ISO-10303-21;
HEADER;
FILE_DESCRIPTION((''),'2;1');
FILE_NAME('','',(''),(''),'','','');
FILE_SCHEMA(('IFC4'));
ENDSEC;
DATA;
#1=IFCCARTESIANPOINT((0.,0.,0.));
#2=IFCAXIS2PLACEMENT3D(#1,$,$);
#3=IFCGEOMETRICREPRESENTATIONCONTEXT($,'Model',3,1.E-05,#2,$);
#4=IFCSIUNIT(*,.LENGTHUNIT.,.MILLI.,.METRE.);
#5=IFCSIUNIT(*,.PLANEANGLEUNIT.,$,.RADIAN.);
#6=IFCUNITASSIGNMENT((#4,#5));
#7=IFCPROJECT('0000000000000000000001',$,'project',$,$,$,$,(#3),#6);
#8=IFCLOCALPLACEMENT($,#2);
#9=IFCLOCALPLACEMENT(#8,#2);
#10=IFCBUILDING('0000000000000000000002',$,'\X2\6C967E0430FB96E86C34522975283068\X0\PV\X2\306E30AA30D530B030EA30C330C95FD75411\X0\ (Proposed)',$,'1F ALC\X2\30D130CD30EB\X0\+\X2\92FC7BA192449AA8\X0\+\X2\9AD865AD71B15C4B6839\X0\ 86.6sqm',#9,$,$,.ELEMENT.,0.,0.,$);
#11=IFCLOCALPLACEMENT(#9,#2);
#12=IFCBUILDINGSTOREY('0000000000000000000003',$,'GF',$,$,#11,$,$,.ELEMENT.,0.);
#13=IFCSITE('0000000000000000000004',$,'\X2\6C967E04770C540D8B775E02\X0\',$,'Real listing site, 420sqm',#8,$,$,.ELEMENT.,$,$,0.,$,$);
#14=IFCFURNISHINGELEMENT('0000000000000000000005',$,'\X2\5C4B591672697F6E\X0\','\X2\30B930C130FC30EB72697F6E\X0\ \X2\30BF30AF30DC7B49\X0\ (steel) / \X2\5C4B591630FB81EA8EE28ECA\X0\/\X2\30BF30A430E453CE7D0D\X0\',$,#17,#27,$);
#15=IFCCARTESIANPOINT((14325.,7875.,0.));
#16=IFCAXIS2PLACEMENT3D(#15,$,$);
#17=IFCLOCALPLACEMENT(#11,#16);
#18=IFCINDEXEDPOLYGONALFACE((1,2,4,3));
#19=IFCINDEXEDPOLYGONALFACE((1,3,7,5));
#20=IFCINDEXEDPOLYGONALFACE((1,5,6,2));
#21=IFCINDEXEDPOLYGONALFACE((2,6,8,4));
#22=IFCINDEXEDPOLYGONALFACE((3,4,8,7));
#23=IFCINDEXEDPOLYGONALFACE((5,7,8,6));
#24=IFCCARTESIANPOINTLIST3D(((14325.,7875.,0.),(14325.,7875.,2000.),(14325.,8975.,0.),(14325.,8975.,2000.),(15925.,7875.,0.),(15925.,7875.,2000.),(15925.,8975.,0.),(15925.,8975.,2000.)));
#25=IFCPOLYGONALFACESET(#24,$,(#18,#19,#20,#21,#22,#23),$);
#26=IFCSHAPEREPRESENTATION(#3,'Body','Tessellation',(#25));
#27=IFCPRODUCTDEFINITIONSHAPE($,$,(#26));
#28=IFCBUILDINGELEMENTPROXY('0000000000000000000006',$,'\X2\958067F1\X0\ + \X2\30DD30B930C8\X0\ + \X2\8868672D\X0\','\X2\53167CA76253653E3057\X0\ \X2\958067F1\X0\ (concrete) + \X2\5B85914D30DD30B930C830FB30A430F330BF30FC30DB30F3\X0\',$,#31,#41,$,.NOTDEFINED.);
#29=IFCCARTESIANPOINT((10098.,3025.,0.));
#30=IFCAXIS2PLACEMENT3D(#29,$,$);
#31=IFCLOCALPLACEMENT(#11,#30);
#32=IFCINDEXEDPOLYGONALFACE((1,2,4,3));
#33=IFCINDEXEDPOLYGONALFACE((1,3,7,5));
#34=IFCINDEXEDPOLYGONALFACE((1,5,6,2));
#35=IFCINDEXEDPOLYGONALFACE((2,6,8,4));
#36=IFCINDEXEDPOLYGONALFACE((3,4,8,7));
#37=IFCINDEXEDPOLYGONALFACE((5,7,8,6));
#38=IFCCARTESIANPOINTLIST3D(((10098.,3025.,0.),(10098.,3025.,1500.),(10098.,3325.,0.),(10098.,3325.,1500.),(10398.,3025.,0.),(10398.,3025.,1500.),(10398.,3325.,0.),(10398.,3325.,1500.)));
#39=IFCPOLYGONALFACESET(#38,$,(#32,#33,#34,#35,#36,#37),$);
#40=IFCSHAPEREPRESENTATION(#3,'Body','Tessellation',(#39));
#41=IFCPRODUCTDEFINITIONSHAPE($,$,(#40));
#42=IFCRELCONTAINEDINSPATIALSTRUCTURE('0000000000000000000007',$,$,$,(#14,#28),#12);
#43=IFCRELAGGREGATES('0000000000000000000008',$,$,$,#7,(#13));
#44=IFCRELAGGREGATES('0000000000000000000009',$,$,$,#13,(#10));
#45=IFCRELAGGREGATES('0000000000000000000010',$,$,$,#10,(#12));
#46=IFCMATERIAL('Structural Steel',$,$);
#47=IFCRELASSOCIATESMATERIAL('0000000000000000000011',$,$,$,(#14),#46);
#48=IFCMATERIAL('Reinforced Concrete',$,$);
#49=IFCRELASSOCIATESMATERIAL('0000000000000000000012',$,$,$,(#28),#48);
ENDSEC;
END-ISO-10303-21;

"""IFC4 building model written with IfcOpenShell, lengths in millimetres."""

from ifc_helpers import new_model, si_unit, frame, frame_2d, origin, place, context, project, spatial, rectangle, extrude, material, element, save


model = new_model("IFC4")

# Units and contexts
model_context = context("Model", 3, precision=1e-05, world=origin())
ifc_project = project(units=[si_unit("LENGTHUNIT", "METRE", prefix="MILLI"), si_unit("PLANEANGLEUNIT", "RADIAN")], contexts=[model_context])

# Site, building, storey
site_placement = place(None, origin())
site = spatial("IfcSite", under=ifc_project, at=site_placement, Name="沖縄県名護市", ObjectType="Real listing site, 420sqm", CompositionType="ELEMENT", RefElevation=0.0)
building_placement = place(site_placement, origin())
building = spatial("IfcBuilding", under=site, at=building_placement, Name="沖縄・雨水利用とPVのオフグリッド志向 (Proposed)", ObjectType="1F ALCパネル+鋼管鉄骨+高断熱屋根 86.6sqm", CompositionType="ELEMENT", ElevationOfRefHeight=0.0, ElevationOfTerrain=0.0)
storey_placement = place(building_placement, origin())
storey = spatial("IfcBuildingStorey", under=building, at=storey_placement, Name="GF", CompositionType="ELEMENT", Elevation=0.0)

# Shared definitions
ifc_material_1 = material(Name="Reinforced Concrete")

# Shared definitions
ifc_material_2 = material(Name="Structural Steel")

# Furnishing element
furnishing_1_placement = place(storey_placement, frame((14325.0, 7875.0, 0.0)))
element("IfcFurnishingElement", 1, at=furnishing_1_placement, inside=storey, material=ifc_material_2, Name="屋外物置", Description="スチール物置 タクボ等 (steel) / 屋外・自転車/タイヤ収納", context=model_context, shape_type="SweptSolid", body=[
    extrude(rectangle(XDim=1600.0, YDim=1100.0, at=frame_2d((800.0, 550.0))), frame((14325.0, 7875.0, 0.0)), (0.0, 0.0, 1.0), 2000.0),
])

# Building element proxy
proxy_placement = place(storey_placement, frame((10098.0, 3025.0, 0.0)))
element("IfcBuildingElementProxy", 2, at=proxy_placement, inside=storey, material=ifc_material_1, Name="門柱 + ポスト + 表札", Description="化粧打放し 門柱 (concrete) + 宅配ポスト・インターホン", PredefinedType="NOTDEFINED", context=model_context, shape_type="SweptSolid", body=[
    extrude(rectangle(XDim=300.0, YDim=300.0, at=frame_2d((150.0, 150.0))), frame((10098.0, 3025.0, 0.0)), (0.0, 0.0, 1.0), 1500.0),
])

save(model, "model.ifc")
